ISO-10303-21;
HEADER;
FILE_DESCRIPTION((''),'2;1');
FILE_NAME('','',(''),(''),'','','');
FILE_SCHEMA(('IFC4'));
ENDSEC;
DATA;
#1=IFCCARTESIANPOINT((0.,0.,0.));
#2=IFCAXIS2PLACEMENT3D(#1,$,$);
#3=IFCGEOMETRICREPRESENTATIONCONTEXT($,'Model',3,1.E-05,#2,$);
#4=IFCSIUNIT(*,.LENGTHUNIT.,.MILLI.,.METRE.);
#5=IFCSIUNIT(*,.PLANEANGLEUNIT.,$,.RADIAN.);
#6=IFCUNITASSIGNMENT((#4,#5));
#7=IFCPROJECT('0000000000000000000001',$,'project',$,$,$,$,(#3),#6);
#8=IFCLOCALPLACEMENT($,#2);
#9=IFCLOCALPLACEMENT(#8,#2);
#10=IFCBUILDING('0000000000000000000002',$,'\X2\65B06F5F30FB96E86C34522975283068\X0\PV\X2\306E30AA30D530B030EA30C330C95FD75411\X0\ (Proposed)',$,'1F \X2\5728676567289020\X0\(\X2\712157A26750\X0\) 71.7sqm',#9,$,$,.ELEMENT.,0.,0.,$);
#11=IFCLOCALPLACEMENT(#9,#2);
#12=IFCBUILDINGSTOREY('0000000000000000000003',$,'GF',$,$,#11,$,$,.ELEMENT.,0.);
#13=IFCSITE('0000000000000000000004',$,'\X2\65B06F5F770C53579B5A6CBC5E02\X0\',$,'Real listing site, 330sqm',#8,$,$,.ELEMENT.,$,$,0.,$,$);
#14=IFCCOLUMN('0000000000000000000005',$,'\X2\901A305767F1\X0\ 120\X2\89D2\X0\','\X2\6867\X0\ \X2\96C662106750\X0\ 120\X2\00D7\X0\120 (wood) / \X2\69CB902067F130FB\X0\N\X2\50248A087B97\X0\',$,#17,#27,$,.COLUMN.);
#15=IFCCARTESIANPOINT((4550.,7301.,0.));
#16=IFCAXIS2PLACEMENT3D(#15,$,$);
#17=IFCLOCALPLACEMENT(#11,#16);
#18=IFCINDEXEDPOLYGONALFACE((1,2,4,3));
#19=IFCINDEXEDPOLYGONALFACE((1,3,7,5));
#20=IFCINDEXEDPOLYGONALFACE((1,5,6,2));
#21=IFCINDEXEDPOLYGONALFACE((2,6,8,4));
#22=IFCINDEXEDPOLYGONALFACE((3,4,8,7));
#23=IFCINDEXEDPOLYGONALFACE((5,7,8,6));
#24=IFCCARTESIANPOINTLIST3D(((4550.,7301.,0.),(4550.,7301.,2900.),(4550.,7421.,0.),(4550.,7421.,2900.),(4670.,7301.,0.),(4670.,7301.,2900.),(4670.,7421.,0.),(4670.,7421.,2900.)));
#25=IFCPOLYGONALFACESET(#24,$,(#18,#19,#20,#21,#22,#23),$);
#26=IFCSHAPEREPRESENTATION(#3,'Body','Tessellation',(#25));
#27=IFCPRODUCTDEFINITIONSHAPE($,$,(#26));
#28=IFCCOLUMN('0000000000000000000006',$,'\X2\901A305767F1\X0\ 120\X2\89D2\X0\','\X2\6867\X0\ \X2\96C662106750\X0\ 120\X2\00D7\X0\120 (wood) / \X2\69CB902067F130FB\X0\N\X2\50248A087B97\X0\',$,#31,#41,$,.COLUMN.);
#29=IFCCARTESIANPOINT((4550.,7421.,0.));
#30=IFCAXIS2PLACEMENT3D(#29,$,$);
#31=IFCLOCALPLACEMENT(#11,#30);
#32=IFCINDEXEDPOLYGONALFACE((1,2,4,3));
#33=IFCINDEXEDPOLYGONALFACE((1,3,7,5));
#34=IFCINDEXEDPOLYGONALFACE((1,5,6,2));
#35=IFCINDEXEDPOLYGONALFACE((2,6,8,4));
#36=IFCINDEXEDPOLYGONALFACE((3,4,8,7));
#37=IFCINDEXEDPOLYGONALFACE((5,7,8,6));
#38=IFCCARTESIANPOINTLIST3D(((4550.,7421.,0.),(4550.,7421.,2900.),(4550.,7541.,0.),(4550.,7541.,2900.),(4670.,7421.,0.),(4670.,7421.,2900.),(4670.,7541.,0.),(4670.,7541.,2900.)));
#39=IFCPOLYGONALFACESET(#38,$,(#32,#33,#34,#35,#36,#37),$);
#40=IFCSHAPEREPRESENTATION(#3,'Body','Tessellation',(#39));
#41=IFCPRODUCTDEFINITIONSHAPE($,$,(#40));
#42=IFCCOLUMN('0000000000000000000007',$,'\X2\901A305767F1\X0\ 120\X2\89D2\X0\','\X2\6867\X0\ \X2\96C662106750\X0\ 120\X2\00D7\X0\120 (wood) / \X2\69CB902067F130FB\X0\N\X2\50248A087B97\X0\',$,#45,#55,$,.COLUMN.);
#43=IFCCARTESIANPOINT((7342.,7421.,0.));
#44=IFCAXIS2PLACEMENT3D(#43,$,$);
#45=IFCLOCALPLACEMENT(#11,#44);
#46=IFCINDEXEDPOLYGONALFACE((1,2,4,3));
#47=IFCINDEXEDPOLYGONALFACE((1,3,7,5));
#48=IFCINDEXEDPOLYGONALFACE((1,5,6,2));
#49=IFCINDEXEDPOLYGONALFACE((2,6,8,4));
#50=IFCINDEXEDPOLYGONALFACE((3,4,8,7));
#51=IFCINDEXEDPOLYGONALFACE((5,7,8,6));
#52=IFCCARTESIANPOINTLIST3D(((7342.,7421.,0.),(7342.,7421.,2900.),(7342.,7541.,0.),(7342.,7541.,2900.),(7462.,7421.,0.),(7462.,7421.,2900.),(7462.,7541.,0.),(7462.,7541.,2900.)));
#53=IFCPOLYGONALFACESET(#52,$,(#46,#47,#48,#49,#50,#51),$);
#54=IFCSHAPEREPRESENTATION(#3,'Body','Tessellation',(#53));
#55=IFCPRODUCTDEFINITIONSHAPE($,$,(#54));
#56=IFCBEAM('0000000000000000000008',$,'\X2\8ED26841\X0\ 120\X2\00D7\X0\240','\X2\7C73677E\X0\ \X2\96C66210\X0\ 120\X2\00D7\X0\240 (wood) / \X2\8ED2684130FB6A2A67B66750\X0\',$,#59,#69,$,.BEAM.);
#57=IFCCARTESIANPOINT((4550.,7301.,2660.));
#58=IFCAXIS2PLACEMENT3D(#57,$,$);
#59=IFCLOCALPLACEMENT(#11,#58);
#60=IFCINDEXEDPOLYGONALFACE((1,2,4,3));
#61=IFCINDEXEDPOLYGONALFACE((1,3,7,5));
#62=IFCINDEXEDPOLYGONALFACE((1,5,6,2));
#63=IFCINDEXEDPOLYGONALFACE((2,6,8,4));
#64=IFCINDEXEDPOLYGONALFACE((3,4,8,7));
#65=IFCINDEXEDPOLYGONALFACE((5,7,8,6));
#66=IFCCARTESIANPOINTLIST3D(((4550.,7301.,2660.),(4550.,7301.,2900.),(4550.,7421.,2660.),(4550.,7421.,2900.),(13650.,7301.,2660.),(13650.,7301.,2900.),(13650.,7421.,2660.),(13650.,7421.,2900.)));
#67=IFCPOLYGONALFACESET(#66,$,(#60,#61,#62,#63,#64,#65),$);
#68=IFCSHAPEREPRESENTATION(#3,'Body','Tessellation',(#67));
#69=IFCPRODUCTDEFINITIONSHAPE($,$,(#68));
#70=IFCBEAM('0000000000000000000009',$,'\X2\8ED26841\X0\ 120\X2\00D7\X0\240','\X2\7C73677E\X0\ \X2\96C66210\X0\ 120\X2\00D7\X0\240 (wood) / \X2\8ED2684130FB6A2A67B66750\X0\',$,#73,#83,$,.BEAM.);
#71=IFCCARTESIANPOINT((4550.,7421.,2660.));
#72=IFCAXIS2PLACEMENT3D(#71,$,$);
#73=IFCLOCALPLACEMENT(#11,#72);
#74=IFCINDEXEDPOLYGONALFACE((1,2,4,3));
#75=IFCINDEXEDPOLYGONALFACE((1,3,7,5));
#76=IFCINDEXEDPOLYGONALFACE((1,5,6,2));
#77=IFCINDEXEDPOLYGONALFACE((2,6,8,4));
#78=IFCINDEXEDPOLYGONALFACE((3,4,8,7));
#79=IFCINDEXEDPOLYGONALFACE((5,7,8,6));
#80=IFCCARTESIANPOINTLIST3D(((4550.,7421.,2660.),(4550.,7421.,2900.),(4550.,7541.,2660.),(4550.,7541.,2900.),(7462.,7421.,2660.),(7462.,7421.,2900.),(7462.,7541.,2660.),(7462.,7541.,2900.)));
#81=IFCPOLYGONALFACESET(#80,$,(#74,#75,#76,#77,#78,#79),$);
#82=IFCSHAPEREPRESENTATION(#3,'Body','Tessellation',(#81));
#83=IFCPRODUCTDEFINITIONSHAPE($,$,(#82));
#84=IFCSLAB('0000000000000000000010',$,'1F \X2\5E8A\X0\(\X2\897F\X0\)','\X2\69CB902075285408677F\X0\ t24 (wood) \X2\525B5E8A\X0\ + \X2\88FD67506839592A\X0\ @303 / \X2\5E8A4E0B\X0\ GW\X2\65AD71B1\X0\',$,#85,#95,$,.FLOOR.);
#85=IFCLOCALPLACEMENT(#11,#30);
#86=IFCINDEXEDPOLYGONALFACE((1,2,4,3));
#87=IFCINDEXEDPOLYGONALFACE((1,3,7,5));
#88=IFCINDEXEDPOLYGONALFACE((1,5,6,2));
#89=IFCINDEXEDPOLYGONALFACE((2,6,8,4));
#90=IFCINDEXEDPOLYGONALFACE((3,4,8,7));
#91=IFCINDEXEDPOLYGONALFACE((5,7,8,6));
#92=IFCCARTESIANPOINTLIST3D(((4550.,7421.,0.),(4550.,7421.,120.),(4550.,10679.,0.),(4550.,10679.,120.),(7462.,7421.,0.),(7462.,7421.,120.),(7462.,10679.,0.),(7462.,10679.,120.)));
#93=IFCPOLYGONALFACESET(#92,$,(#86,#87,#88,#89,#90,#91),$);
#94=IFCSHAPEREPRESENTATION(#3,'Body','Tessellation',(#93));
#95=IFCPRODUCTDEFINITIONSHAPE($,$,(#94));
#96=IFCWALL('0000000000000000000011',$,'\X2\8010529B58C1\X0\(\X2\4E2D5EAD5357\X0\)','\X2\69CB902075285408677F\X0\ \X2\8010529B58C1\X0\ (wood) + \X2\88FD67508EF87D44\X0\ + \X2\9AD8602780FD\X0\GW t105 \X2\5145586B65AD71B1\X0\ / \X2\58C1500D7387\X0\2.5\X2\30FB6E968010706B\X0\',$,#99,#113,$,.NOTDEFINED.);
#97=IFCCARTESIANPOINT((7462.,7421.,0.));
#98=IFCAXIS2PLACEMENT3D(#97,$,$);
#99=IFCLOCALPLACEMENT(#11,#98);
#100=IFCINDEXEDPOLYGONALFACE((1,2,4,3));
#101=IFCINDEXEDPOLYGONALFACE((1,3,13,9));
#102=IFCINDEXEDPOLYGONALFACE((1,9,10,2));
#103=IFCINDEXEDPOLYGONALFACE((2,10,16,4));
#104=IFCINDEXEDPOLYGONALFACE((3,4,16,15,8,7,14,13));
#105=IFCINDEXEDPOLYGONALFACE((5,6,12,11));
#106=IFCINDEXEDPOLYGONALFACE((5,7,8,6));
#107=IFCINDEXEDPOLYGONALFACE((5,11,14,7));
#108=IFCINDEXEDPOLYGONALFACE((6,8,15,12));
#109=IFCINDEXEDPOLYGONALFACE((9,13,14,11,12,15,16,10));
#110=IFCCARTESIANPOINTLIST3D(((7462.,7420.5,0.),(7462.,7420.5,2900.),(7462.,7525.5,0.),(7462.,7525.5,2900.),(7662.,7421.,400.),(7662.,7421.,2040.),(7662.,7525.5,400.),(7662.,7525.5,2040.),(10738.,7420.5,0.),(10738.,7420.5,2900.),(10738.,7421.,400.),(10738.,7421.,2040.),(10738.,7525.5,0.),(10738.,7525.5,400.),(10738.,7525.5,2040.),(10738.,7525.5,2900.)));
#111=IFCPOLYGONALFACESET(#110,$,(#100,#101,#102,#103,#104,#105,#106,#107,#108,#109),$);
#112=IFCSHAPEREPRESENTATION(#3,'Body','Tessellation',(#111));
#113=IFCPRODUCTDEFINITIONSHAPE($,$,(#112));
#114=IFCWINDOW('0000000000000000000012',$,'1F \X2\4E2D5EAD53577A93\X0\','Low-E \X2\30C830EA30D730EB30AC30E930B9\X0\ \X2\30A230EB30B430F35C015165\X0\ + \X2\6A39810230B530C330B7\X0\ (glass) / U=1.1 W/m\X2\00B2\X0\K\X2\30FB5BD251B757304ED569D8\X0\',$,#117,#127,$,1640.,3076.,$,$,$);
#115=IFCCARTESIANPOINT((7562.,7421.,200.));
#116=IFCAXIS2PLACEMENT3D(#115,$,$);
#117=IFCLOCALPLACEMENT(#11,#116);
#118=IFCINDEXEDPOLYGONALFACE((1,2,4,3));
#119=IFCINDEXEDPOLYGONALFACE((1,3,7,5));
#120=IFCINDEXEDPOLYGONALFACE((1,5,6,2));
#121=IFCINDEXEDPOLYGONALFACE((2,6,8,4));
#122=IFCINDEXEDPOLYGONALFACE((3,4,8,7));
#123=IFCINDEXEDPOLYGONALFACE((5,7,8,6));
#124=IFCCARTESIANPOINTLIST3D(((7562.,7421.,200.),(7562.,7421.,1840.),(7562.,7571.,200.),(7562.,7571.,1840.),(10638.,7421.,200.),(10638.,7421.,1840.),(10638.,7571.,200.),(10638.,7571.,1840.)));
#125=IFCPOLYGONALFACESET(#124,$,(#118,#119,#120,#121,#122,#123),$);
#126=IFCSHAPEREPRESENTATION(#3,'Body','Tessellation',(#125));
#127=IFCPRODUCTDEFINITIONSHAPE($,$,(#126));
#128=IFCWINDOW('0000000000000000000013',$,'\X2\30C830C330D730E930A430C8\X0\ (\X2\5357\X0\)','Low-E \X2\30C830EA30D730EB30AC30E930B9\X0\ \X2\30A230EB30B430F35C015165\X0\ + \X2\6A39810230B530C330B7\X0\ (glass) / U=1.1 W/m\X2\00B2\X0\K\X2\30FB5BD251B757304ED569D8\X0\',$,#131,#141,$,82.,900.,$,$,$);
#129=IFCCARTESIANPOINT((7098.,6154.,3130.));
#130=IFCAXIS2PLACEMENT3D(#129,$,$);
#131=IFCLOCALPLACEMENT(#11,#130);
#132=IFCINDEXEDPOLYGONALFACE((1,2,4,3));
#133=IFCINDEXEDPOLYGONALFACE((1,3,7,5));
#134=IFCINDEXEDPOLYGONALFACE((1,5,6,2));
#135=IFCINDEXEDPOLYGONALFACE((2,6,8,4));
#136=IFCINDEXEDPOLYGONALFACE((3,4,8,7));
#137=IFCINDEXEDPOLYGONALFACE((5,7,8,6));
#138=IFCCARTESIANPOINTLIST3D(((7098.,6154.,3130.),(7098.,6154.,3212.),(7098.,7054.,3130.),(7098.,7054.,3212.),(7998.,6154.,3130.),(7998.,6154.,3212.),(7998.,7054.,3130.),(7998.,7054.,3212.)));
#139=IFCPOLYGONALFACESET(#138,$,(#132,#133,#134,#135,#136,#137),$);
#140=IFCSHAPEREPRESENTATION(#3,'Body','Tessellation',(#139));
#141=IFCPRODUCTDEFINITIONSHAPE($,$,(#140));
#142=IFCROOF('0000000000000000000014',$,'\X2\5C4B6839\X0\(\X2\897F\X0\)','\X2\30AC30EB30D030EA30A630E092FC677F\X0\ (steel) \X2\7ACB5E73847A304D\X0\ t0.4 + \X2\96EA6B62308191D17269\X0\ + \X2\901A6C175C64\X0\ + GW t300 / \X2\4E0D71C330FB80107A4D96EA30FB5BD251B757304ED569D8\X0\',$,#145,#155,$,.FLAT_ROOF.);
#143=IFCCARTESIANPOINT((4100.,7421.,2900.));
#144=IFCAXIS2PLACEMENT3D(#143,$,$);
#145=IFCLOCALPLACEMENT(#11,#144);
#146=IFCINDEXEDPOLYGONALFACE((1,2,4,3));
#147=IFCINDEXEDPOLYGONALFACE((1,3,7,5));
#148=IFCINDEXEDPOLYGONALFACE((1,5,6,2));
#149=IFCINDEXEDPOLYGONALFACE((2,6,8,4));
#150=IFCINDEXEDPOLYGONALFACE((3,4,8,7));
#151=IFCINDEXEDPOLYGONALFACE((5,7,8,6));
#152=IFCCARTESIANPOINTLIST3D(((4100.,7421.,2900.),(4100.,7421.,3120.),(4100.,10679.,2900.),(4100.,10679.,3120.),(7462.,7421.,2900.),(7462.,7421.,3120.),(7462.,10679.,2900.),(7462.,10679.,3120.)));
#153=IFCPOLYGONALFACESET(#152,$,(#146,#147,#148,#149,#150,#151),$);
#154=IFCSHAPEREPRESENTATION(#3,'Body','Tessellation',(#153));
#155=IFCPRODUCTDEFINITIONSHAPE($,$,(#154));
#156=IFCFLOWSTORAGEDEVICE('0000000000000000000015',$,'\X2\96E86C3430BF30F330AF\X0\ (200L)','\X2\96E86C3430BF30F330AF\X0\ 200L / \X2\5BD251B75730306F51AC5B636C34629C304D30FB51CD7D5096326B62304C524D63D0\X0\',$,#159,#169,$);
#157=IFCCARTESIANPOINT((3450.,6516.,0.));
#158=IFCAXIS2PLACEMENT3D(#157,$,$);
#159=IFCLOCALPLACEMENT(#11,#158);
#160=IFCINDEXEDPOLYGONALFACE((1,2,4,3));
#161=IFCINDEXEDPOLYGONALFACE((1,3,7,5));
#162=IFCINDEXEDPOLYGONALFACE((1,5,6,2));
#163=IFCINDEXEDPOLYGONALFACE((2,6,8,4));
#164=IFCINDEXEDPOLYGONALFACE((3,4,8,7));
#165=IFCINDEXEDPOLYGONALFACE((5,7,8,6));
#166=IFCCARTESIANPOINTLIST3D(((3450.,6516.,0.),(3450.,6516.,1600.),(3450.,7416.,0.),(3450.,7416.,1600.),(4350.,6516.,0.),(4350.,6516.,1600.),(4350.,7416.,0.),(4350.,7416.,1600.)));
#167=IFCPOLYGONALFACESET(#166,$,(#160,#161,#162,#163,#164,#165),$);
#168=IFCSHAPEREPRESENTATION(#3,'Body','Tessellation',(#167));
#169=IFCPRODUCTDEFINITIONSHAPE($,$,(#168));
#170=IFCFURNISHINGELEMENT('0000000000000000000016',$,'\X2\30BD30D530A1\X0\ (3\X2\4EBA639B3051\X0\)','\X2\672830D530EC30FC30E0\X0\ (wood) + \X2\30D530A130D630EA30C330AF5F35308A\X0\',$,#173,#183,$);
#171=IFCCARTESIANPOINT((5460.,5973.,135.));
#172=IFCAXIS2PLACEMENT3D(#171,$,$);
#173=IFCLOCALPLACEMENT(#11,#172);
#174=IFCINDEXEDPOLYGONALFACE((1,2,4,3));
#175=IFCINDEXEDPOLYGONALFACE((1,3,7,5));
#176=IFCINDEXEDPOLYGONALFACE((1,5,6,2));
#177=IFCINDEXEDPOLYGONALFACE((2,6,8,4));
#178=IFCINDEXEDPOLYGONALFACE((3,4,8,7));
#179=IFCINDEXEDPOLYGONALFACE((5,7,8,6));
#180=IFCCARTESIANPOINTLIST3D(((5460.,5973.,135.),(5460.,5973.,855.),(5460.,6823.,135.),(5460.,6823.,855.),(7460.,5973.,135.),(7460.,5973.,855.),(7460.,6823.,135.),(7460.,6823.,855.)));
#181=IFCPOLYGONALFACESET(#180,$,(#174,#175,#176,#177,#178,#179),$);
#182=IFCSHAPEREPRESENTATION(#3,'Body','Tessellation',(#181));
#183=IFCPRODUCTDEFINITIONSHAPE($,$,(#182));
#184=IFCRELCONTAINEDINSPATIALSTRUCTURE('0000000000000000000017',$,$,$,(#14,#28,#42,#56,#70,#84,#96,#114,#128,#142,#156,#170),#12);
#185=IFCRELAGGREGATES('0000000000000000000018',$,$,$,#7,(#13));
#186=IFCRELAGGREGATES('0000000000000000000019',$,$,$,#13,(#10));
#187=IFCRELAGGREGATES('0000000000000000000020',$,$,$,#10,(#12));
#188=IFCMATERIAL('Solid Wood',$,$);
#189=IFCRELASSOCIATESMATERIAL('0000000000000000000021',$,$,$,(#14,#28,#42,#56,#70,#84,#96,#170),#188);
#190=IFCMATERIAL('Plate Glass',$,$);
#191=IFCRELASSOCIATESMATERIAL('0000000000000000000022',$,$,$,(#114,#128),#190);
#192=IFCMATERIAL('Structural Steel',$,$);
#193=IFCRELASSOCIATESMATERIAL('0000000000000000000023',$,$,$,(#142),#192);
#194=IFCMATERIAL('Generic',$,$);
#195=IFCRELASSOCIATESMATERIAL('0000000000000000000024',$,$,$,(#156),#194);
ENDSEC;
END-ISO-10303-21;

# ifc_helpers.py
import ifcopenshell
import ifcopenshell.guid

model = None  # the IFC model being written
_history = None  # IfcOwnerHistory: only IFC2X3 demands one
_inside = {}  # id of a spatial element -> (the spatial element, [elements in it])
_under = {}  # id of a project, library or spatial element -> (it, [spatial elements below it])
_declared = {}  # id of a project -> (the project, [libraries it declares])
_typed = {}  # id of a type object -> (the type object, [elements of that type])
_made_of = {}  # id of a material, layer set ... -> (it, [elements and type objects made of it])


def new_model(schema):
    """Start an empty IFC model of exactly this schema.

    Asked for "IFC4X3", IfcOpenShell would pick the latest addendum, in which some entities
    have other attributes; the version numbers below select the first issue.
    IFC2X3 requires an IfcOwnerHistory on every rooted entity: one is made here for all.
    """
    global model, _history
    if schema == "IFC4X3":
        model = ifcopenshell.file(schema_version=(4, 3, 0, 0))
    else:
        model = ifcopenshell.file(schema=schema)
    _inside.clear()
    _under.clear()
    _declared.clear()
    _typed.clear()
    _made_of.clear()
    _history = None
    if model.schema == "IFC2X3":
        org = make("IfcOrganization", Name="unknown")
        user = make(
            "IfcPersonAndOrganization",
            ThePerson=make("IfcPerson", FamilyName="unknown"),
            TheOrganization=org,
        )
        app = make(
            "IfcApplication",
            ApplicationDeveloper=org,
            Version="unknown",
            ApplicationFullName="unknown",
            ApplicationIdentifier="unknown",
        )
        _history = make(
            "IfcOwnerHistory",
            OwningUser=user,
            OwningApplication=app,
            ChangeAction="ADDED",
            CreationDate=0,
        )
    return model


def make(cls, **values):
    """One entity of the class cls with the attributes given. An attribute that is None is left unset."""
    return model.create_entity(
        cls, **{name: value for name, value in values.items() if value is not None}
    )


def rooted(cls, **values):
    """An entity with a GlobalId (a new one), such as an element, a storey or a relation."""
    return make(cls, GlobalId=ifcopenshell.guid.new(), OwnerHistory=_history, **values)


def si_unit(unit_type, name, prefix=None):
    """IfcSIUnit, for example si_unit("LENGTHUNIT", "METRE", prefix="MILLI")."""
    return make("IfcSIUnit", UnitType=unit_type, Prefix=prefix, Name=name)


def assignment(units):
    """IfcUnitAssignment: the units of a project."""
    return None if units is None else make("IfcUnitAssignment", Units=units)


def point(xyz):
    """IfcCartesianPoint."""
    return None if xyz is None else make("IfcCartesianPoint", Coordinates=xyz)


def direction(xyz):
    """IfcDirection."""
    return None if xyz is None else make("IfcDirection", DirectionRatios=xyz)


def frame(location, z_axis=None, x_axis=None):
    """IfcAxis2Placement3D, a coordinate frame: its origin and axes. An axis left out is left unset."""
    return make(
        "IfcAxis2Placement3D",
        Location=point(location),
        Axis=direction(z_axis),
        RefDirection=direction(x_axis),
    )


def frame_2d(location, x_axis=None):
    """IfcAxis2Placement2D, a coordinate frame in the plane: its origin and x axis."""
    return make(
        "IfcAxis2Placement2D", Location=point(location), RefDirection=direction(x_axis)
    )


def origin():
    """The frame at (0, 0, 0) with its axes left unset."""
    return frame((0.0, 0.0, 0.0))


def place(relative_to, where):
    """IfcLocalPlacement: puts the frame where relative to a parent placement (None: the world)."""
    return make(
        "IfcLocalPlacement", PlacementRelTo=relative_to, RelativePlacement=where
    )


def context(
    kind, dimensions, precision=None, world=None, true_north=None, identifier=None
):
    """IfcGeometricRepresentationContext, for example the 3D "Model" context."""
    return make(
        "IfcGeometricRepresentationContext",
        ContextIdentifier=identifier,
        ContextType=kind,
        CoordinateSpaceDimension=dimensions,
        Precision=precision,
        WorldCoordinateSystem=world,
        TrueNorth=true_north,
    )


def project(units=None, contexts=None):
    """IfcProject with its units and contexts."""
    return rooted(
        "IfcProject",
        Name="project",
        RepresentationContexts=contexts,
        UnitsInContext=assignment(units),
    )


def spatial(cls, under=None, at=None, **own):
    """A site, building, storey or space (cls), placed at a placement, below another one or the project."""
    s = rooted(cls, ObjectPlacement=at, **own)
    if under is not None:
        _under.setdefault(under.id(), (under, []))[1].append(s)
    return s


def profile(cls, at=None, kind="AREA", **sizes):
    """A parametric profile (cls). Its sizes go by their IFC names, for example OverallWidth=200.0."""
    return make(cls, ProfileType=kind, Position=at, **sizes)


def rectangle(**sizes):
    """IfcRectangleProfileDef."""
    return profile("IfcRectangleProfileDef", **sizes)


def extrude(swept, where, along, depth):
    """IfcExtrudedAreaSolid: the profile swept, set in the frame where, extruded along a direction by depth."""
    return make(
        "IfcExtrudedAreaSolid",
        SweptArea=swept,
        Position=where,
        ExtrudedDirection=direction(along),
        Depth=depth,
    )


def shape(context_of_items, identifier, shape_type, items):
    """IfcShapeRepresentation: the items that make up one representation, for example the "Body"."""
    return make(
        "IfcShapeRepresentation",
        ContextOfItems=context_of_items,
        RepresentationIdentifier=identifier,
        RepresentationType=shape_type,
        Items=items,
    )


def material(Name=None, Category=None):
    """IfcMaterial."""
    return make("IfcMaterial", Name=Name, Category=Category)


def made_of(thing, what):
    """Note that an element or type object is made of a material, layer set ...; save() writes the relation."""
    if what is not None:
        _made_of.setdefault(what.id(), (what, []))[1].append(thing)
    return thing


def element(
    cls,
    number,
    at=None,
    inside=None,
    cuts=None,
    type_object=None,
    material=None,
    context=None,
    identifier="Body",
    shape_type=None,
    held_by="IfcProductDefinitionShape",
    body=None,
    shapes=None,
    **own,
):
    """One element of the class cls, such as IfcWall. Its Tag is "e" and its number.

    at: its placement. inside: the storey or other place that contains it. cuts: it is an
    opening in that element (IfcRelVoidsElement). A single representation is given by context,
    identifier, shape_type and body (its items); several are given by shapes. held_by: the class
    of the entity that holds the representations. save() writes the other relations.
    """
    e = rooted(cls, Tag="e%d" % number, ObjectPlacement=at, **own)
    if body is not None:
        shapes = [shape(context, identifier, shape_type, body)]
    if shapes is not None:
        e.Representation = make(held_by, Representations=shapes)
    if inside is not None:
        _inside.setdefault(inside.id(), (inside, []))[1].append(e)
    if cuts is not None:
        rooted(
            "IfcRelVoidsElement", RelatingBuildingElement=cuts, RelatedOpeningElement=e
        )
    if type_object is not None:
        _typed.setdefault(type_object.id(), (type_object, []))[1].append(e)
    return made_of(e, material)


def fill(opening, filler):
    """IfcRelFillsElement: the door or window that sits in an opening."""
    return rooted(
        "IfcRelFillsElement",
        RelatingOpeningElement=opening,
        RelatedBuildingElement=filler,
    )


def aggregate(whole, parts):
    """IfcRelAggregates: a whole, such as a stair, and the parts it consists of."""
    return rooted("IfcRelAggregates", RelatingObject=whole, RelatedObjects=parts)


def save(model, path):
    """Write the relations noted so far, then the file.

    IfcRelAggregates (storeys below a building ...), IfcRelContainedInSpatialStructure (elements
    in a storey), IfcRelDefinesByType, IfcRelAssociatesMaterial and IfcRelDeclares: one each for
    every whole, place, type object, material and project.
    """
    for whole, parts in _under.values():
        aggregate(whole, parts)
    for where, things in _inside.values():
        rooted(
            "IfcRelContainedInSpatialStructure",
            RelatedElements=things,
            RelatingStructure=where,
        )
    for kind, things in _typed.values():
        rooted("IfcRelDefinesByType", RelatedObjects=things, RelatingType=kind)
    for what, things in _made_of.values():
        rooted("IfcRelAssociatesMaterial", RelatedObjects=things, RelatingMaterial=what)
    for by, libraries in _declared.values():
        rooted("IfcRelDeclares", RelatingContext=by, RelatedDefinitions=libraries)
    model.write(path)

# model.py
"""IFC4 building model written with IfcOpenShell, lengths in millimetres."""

from ifc_helpers import new_model, si_unit, frame, frame_2d, origin, place, context, project, spatial, rectangle, extrude, material, element, fill, save


model = new_model("IFC4")

# Units and contexts
model_context = context("Model", 3, precision=1e-05, world=origin())
ifc_project = project(units=[si_unit("LENGTHUNIT", "METRE", prefix="MILLI"), si_unit("PLANEANGLEUNIT", "RADIAN")], contexts=[model_context])

# Site, building, storey
site_placement = place(None, origin())
site = spatial("IfcSite", under=ifc_project, at=site_placement, Name="新潟県南魚沼市", ObjectType="Real listing site, 330sqm", CompositionType="ELEMENT", RefElevation=0.0)
building_placement = place(site_placement, origin())
building = spatial("IfcBuilding", under=site, at=building_placement, Name="新潟・雨水利用とPVのオフグリッド志向 (Proposed)", ObjectType="1F 在来木造(無垢材) 71.7sqm", CompositionType="ELEMENT", ElevationOfRefHeight=0.0, ElevationOfTerrain=0.0)
storey_placement = place(building_placement, origin())
storey = spatial("IfcBuildingStorey", under=building, at=storey_placement, Name="GF", CompositionType="ELEMENT", Elevation=0.0)

# Columns
ifc_material_1 = material(Name="Solid Wood")
column_1_placement = place(storey_placement, frame((4550.0, 7301.0, 0.0)))
element("IfcColumn", 1, at=column_1_placement, inside=storey, material=ifc_material_1, Name="通し柱 120角", Description="桧 集成材 120×120 (wood) / 構造柱・N値計算", PredefinedType="COLUMN", context=model_context, shape_type="SweptSolid", body=[
    extrude(rectangle(XDim=120.0, YDim=120.0, at=frame_2d((60.0, 60.0))), frame((4550.0, 7301.0, 0.0)), (0.0, 0.0, 1.0), 2900.0),
])
column_2_placement = place(storey_placement, frame((4550.0, 7421.0, 0.0)))
element("IfcColumn", 2, at=column_2_placement, inside=storey, material=ifc_material_1, Name="通し柱 120角", Description="桧 集成材 120×120 (wood) / 構造柱・N値計算", PredefinedType="COLUMN", context=model_context, shape_type="SweptSolid", body=[
    extrude(rectangle(XDim=120.0, YDim=120.0, at=frame_2d((60.0, 60.0))), frame((4550.0, 7421.0, 0.0)), (0.0, 0.0, 1.0), 2900.0),
])
column_3_placement = place(storey_placement, frame((7342.0, 7421.0, 0.0)))
element("IfcColumn", 3, at=column_3_placement, inside=storey, material=ifc_material_1, Name="通し柱 120角", Description="桧 集成材 120×120 (wood) / 構造柱・N値計算", PredefinedType="COLUMN", context=model_context, shape_type="SweptSolid", body=[
    extrude(rectangle(XDim=120.0, YDim=120.0, at=frame_2d((60.0, 60.0))), frame((7342.0, 7421.0, 0.0)), (0.0, 0.0, 1.0), 2900.0),
])

# Beams
beam_1_placement = place(storey_placement, frame((4550.0, 7301.0, 2660.0)))
element("IfcBeam", 4, at=beam_1_placement, inside=storey, material=ifc_material_1, Name="軒桁 120×240", Description="米松 集成 120×240 (wood) / 軒桁・横架材", PredefinedType="BEAM", context=model_context, shape_type="SweptSolid", body=[
    extrude(rectangle(XDim=9100.0, YDim=120.0, at=frame_2d((4550.0, 60.0))), frame((4550.0, 7301.0, 2660.0)), (0.0, 0.0, 1.0), 240.0),
])
beam_2_placement = place(storey_placement, frame((4550.0, 7421.0, 2660.0)))
element("IfcBeam", 5, at=beam_2_placement, inside=storey, material=ifc_material_1, Name="軒桁 120×240", Description="米松 集成 120×240 (wood) / 軒桁・横架材", PredefinedType="BEAM", context=model_context, shape_type="SweptSolid", body=[
    extrude(rectangle(XDim=2912.0, YDim=120.0, at=frame_2d((1456.0, 60.0))), frame((4550.0, 7421.0, 2660.0)), (0.0, 0.0, 1.0), 240.0),
])

# Slab
slab_placement = place(storey_placement, frame((4550.0, 7421.0, 0.0)))
element("IfcSlab", 6, at=slab_placement, inside=storey, material=ifc_material_1, Name="1F 床(西)", Description="構造用合板 t24 (wood) 剛床 + 製材根太 @303 / 床下 GW断熱", PredefinedType="FLOOR", context=model_context, shape_type="SweptSolid", body=[
    extrude(rectangle(XDim=2912.0, YDim=3258.0, at=frame_2d((1456.0, 1629.0))), frame((4550.0, 7421.0, 0.0)), (0.0, 0.0, 1.0), 120.0),
])

# Wall, opening, window
wall_placement = place(storey_placement, frame((7462.0, 7421.0, 0.0)))
wall = element("IfcWall", 7, at=wall_placement, inside=storey, material=ifc_material_1, Name="耐力壁(中庭南)", Description="構造用合板 耐力壁 (wood) + 製材軸組 + 高性能GW t105 充填断熱 / 壁倍率2.5・準耐火", PredefinedType="NOTDEFINED", context=model_context, shape_type="SweptSolid", body=[
    extrude(rectangle(XDim=3276.0, YDim=105.0, at=frame_2d((1638.0, 52.0))), frame((7462.0, 7421.0, 0.0)), (0.0, 0.0, 1.0), 2900.0),
])
opening_placement = place(storey_placement, frame((7562.0, 7421.0, 200.0)))
opening = element("IfcOpeningElement", 8, at=opening_placement, cuts=wall, PredefinedType="NOTDEFINED", context=model_context, shape_type="SweptSolid", body=[
    extrude(rectangle(XDim=3076.0, YDim=150.0, at=frame_2d((1538.0, 75.0))), frame((7562.0, 7421.0, 200.0)), (0.0, 0.0, 1.0), 1640.0),
])
ifc_material_2 = material(Name="Plate Glass")
window_1_placement = place(storey_placement, frame((7562.0, 7421.0, 200.0)))
window_1 = element("IfcWindow", 9, at=window_1_placement, inside=storey, material=ifc_material_2, Name="1F 中庭南窓", Description="Low-E トリプルガラス アルゴン封入 + 樹脂サッシ (glass) / U=1.1 W/m²K・寒冷地仕様", OverallHeight=1640.0, OverallWidth=3076.0, context=model_context, shape_type="SweptSolid", body=[
    extrude(rectangle(XDim=3076.0, YDim=150.0, at=frame_2d((1538.0, 75.0))), frame((7562.0, 7421.0, 200.0)), (0.0, 0.0, 1.0), 1640.0),
])
fill(opening, window_1)

# Window
window_2_placement = place(storey_placement, frame((7098.0, 6154.0, 3130.0)))
element("IfcWindow", 10, at=window_2_placement, inside=storey, material=ifc_material_2, Name="トップライト (南)", Description="Low-E トリプルガラス アルゴン封入 + 樹脂サッシ (glass) / U=1.1 W/m²K・寒冷地仕様", OverallHeight=82.0, OverallWidth=900.0, context=model_context, shape_type="SweptSolid", body=[
    extrude(rectangle(XDim=900.0, YDim=900.0, at=frame_2d((450.0, 450.0))), frame((7098.0, 6154.0, 3130.0)), (0.0, 0.0, 1.0), 82.0),
])

# Roof
ifc_material_3 = material(Name="Structural Steel")
roof_placement = place(storey_placement, frame((4100.0, 7421.0, 2900.0)))
element("IfcRoof", 11, at=roof_placement, inside=storey, material=ifc_material_3, Name="屋根(西)", Description="ガルバリウム鋼板 (steel) 立平葺き t0.4 + 雪止め金物 + 通気層 + GW t300 / 不燃・耐積雪・寒冷地仕様", PredefinedType="FLAT_ROOF", context=model_context, shape_type="SweptSolid", body=[
    extrude(rectangle(XDim=3362.0, YDim=3258.0, at=frame_2d((1681.0, 1629.0))), frame((4100.0, 7421.0, 2900.0)), (0.0, 0.0, 1.0), 220.0),
])

# Flow storage device
ifc_material_4 = material(Name="Generic")
flow_storage_device_placement = place(storey_placement, frame((3450.0, 6516.0, 0.0)))
element("IfcFlowStorageDevice", 12, at=flow_storage_device_placement, inside=storey, material=ifc_material_4, Name="雨水タンク (200L)", Description="雨水タンク 200L / 寒冷地は冬季水抜き・凍結防止が前提", context=model_context, shape_type="SweptSolid", body=[
    extrude(rectangle(XDim=900.0, YDim=900.0, at=frame_2d((450.0, 450.0))), frame((3450.0, 6516.0, 0.0)), (0.0, 0.0, 1.0), 1600.0),
])

# Furnishing element
furnishing_placement = place(storey_placement, frame((5460.0, 5973.0, 135.0)))
element("IfcFurnishingElement", 13, at=furnishing_placement, inside=storey, material=ifc_material_1, Name="ソファ (3人掛け)", Description="木フレーム (wood) + ファブリック張り", context=model_context, shape_type="SweptSolid", body=[
    extrude(rectangle(XDim=2000.0, YDim=850.0, at=frame_2d((1000.0, 425.0))), frame((5460.0, 5973.0, 135.0)), (0.0, 0.0, 1.0), 720.0),
])

save(model, "model.ifc")
